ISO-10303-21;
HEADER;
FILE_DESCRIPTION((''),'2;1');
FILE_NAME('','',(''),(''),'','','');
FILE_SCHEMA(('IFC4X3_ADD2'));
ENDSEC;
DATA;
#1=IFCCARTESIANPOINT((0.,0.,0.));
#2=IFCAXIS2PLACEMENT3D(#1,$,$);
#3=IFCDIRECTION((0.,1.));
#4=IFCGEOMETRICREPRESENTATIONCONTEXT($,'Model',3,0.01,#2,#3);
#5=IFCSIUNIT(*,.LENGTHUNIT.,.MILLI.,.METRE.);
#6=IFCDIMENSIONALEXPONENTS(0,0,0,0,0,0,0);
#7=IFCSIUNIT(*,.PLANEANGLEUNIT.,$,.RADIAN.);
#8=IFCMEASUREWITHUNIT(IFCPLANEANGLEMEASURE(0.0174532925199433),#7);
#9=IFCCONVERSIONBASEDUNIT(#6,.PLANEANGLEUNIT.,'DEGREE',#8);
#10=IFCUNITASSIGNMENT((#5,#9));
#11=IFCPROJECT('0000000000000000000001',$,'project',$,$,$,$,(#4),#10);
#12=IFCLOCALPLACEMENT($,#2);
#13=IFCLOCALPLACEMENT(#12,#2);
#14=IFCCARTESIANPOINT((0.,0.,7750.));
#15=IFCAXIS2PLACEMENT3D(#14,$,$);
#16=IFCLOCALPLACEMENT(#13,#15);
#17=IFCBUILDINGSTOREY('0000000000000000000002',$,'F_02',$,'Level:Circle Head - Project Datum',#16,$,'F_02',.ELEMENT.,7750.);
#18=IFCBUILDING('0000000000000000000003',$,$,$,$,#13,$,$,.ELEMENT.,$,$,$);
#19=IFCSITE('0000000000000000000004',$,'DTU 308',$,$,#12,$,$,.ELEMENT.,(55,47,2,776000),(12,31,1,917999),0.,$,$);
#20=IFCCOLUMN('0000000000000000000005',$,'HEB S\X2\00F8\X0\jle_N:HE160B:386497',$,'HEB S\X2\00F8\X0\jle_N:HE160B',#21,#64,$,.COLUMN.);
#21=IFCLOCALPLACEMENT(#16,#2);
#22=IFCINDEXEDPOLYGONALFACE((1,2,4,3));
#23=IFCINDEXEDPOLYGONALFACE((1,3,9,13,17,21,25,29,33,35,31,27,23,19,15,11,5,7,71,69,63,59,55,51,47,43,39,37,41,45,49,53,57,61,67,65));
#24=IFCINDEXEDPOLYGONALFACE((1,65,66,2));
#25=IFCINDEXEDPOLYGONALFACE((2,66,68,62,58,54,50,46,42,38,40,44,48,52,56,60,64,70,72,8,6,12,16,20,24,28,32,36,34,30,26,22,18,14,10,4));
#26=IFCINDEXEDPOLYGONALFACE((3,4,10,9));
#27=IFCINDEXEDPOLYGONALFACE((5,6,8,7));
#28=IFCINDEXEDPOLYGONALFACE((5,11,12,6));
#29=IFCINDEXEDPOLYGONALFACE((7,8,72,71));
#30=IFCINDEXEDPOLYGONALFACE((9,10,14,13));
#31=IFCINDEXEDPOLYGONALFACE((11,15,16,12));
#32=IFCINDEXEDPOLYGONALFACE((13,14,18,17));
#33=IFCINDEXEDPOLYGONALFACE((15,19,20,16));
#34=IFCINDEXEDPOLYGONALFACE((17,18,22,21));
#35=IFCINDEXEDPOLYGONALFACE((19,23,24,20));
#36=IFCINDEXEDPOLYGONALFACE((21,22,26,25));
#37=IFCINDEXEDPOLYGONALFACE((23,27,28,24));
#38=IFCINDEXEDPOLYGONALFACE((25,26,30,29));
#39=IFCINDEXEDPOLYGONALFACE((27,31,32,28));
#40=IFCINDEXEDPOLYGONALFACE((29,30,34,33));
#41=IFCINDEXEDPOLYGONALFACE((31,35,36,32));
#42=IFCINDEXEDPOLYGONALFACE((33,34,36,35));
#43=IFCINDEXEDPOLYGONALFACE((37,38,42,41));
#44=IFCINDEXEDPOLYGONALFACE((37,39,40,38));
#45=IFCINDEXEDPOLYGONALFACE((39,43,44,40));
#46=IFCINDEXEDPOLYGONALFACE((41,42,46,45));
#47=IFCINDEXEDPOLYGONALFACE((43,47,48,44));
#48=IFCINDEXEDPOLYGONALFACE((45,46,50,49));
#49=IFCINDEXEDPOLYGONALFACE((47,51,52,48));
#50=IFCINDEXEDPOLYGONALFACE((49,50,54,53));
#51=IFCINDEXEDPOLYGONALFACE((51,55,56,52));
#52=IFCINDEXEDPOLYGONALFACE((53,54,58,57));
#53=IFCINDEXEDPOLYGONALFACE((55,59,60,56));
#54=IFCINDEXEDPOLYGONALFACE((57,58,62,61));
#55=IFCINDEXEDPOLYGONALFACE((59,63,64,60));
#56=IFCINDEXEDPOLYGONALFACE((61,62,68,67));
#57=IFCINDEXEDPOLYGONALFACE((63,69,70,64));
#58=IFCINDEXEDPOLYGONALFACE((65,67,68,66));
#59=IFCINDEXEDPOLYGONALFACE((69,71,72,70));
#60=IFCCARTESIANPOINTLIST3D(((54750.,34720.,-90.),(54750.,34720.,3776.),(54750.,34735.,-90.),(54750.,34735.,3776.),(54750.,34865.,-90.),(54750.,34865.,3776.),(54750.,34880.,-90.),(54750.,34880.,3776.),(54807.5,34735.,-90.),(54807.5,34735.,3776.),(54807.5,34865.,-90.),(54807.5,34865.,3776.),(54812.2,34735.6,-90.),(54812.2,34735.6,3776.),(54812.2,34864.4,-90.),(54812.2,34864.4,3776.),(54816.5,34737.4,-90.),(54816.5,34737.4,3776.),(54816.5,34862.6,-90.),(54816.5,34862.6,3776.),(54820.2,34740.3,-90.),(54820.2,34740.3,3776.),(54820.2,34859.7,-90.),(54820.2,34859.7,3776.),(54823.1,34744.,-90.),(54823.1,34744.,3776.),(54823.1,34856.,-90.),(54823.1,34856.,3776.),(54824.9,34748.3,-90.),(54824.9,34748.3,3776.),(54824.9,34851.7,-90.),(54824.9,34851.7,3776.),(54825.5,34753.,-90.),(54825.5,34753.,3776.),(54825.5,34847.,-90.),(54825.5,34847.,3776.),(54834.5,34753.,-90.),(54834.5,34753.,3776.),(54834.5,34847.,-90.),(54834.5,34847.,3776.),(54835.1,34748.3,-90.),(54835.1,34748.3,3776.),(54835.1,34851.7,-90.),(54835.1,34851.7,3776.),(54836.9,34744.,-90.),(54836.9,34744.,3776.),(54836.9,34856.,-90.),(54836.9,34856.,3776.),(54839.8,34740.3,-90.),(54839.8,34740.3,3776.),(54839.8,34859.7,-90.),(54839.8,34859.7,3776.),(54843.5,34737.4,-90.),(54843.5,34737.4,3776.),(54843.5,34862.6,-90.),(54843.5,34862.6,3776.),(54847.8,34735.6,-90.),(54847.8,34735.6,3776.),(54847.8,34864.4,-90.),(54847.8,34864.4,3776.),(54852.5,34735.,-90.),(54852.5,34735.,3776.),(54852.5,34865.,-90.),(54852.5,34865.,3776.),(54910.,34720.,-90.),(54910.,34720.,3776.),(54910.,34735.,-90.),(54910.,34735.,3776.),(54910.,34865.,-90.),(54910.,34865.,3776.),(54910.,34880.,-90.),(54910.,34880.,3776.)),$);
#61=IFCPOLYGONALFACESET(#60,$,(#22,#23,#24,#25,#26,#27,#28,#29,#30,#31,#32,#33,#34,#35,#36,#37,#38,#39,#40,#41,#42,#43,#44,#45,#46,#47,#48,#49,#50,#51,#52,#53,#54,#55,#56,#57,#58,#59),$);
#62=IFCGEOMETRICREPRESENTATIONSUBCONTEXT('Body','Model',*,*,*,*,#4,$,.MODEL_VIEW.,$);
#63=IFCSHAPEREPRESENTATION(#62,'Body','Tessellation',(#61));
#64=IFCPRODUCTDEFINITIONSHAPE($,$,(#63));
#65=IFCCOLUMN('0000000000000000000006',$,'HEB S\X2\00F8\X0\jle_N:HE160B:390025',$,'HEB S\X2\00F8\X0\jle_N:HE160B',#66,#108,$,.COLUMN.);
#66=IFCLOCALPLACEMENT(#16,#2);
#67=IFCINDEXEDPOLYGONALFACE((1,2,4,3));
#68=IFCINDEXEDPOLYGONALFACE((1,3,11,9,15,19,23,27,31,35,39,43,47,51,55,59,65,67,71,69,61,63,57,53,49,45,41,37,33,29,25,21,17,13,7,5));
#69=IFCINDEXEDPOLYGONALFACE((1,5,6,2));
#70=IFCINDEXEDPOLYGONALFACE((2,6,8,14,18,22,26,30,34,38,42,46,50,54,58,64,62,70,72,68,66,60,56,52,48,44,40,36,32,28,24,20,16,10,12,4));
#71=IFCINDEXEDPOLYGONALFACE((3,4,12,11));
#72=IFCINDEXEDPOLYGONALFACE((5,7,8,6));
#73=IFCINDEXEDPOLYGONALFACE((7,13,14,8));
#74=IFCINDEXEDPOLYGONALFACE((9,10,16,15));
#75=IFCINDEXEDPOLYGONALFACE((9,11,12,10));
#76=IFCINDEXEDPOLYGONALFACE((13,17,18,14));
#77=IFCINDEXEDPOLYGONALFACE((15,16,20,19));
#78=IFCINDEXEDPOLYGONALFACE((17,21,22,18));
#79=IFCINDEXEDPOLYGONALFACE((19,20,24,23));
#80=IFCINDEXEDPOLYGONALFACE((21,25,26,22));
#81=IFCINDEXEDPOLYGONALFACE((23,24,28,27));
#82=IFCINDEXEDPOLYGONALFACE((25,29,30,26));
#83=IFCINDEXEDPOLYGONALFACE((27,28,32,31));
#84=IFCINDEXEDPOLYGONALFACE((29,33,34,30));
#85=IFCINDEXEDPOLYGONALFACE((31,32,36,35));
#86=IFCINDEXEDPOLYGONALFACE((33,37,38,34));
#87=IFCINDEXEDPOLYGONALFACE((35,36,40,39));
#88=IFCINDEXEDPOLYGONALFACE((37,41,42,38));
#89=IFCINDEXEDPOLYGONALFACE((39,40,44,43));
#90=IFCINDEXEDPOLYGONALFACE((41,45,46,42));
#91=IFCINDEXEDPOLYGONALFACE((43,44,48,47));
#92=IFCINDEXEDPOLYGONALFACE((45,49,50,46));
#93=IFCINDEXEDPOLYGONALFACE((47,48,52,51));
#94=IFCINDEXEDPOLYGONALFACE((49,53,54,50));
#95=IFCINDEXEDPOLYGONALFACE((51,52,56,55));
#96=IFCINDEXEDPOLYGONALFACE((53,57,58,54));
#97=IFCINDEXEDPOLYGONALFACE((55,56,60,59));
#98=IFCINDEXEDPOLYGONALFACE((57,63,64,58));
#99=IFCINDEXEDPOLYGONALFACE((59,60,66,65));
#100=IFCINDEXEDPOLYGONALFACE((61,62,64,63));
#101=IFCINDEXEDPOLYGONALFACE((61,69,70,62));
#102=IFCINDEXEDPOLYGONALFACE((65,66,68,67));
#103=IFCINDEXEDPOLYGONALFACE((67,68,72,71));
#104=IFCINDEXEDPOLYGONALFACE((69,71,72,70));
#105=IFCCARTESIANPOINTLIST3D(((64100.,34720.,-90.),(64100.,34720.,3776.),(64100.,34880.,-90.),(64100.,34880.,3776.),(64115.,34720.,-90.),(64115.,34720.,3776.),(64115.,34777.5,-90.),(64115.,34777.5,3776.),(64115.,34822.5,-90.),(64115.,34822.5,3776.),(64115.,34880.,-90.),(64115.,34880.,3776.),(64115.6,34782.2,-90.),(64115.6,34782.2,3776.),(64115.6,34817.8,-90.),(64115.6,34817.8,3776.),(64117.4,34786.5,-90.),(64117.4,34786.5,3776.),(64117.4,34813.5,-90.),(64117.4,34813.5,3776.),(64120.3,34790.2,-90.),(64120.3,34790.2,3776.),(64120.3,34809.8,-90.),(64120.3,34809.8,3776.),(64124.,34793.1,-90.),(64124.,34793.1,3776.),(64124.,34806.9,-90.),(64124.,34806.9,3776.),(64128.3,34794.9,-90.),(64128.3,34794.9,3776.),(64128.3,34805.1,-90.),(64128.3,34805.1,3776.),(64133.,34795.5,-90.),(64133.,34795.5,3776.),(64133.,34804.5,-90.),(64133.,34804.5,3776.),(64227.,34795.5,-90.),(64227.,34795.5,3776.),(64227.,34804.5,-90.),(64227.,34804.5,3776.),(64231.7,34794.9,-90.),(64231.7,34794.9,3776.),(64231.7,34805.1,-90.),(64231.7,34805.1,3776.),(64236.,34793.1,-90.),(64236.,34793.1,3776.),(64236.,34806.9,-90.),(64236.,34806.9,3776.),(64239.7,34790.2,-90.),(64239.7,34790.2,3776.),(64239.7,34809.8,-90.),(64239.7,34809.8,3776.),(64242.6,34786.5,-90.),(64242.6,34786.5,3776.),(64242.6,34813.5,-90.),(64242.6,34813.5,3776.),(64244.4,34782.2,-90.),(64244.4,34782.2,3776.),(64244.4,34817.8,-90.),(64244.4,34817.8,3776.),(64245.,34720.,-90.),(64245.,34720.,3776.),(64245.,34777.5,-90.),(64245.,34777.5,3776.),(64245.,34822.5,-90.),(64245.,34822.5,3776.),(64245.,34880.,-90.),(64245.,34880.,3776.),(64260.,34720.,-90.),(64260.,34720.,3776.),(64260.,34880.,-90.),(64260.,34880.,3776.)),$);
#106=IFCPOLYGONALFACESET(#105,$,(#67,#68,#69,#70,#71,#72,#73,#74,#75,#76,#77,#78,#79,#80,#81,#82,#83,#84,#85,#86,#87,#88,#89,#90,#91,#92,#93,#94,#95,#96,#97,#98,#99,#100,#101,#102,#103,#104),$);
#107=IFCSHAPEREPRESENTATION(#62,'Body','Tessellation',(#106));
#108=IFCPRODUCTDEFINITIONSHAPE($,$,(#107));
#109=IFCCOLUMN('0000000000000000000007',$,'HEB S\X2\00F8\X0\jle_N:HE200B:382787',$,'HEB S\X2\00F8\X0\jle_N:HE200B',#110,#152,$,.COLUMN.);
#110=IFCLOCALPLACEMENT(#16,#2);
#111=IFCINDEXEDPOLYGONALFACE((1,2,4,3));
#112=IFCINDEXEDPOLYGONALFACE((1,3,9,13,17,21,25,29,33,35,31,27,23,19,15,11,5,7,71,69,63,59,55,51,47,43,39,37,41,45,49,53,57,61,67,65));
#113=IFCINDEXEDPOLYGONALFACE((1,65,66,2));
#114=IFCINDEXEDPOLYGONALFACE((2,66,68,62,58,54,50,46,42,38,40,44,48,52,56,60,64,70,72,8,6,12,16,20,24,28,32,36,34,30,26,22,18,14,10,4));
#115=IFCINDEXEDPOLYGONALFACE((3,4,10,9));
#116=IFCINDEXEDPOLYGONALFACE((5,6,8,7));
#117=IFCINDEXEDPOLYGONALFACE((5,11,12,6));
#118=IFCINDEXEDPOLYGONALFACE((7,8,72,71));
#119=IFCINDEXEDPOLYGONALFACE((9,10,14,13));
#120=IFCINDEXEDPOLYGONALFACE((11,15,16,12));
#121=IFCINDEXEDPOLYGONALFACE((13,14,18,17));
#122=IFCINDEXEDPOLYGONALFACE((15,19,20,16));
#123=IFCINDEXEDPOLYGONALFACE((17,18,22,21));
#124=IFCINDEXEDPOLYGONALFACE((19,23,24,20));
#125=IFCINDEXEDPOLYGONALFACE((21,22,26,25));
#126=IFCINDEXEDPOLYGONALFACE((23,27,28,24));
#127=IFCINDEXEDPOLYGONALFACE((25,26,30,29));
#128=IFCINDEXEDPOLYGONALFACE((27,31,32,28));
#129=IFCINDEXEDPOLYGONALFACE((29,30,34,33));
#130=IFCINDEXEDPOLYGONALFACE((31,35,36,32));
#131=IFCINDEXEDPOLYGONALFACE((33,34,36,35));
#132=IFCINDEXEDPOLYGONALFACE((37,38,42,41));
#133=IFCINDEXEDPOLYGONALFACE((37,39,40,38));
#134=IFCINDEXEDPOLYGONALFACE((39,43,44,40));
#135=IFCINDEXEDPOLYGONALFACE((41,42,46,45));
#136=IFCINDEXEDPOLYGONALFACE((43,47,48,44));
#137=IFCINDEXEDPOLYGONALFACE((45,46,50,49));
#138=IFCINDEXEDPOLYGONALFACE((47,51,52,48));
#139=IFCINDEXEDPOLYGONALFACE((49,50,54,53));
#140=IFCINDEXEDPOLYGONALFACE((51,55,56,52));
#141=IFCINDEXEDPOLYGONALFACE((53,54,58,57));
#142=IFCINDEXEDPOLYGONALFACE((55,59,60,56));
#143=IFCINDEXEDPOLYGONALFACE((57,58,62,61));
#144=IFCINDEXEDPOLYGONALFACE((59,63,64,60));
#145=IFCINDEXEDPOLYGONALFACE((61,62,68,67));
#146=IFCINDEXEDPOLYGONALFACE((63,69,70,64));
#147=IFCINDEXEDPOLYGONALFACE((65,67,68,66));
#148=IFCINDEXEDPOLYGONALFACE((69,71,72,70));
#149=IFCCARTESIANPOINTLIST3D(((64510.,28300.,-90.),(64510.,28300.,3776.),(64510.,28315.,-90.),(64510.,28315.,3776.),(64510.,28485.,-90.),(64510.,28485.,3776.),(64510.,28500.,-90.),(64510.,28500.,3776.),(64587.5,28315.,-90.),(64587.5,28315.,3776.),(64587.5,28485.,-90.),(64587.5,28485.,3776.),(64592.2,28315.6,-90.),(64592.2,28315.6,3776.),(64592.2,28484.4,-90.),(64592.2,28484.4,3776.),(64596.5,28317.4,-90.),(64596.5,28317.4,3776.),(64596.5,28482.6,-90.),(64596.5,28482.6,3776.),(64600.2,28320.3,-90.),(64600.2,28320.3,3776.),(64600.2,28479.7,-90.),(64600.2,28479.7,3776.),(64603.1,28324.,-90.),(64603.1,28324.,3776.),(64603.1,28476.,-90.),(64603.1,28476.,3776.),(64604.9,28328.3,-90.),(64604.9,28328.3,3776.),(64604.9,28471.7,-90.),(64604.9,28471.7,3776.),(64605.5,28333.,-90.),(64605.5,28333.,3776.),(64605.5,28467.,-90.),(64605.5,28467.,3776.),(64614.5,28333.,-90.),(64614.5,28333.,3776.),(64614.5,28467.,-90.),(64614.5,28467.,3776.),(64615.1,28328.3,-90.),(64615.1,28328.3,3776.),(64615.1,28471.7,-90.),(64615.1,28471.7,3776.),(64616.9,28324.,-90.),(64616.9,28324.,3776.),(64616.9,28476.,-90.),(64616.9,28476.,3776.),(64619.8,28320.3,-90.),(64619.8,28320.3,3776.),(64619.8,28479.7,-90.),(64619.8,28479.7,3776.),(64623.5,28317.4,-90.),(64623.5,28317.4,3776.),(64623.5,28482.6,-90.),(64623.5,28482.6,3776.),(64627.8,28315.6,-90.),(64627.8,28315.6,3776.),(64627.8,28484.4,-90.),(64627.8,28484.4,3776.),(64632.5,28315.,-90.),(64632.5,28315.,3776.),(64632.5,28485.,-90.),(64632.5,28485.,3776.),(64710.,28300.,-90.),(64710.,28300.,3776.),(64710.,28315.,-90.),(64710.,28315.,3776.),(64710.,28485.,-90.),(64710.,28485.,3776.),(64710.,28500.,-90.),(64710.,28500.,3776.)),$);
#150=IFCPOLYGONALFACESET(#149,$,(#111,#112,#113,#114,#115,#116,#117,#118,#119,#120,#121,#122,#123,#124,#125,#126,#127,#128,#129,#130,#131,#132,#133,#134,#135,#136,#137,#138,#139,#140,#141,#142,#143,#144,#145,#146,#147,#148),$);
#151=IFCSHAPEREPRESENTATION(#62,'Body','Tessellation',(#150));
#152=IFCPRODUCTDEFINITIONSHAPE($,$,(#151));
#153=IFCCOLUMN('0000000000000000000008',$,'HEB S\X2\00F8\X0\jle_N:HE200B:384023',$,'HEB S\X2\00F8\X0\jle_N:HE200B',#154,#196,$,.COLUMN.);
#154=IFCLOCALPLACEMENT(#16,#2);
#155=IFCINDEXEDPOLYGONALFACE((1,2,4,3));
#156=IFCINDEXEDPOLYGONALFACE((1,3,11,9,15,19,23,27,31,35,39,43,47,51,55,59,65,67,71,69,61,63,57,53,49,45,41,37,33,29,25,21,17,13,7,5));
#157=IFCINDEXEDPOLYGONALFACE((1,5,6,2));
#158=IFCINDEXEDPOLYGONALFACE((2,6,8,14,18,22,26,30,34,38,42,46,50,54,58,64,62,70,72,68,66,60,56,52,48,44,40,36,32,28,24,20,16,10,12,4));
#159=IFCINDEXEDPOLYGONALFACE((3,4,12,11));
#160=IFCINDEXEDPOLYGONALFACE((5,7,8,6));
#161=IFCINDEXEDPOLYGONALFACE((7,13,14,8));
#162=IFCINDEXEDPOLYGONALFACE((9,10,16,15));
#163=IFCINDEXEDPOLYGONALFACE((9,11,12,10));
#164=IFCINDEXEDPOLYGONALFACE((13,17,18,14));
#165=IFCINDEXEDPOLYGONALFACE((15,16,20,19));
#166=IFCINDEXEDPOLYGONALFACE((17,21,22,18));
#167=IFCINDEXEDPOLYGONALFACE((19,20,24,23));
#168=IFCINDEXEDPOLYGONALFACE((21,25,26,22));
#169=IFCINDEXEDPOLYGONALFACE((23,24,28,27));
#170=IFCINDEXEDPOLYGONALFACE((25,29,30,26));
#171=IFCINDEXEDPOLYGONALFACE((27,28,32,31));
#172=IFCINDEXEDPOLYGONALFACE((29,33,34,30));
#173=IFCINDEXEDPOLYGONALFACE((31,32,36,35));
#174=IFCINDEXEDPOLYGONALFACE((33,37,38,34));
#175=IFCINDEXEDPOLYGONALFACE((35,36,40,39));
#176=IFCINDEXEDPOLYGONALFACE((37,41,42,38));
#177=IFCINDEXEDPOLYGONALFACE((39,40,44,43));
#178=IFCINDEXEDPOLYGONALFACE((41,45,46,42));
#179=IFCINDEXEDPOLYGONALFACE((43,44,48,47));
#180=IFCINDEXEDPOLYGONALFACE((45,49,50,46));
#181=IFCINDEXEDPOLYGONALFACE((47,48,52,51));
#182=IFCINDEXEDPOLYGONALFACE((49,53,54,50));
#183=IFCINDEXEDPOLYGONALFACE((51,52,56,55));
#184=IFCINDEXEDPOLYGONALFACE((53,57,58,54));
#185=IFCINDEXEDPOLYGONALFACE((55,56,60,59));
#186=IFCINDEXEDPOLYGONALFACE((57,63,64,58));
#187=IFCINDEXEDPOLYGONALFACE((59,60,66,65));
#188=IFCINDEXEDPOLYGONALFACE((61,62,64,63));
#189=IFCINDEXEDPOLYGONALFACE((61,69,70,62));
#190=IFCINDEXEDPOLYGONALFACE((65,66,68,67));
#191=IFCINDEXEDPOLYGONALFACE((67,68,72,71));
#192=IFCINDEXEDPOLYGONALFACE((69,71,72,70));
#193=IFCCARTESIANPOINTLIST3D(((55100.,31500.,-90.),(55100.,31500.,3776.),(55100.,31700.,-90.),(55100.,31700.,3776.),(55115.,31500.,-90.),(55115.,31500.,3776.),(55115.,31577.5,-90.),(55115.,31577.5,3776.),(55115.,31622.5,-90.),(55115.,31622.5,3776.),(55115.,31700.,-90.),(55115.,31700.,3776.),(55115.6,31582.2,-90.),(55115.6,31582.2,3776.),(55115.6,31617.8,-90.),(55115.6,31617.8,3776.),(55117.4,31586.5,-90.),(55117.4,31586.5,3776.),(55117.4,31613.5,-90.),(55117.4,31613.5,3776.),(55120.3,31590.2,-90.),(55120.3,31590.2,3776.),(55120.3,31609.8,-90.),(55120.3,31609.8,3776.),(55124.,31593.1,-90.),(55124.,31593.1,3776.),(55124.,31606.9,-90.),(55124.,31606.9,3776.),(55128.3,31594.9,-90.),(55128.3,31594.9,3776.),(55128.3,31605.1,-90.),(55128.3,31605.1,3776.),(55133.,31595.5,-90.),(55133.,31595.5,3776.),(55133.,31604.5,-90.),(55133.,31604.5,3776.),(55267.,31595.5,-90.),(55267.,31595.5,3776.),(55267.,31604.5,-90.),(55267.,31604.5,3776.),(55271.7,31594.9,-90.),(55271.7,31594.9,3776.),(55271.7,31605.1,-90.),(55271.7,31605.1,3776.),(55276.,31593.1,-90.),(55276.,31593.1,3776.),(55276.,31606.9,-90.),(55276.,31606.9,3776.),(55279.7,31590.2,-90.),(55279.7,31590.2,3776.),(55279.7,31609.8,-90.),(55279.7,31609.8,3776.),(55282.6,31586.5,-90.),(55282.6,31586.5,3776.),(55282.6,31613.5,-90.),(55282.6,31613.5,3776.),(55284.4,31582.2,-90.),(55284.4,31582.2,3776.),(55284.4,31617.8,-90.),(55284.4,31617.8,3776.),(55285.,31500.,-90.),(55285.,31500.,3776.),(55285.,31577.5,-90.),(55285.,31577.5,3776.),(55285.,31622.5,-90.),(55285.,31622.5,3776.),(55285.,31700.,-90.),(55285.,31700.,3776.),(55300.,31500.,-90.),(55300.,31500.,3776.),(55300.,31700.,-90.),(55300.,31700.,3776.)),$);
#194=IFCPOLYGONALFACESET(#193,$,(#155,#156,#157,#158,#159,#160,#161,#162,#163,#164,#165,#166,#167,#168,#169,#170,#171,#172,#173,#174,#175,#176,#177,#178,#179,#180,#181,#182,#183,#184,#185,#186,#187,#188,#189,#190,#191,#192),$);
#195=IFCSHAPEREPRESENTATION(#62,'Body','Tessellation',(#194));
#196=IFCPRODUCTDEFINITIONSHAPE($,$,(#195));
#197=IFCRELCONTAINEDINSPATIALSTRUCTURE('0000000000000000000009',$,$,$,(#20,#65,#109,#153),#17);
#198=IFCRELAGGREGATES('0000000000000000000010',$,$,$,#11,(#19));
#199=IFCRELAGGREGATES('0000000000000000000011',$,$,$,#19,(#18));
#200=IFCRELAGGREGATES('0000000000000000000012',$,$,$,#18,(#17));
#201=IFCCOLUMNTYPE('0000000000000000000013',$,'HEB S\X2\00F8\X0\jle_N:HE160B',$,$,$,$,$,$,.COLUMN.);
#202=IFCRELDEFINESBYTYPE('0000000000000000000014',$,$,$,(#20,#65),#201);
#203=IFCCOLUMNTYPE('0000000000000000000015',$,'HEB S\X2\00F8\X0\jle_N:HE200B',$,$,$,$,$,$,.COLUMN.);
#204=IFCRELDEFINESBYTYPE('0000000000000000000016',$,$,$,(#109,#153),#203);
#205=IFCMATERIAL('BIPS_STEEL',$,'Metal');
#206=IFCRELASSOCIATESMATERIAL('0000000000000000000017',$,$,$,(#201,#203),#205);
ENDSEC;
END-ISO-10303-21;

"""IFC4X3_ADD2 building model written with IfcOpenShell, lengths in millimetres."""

from ifc_helpers import new_model, entity, si_unit, converted_unit, direction, frame, frame_2d, origin, place, context, subcontext, project, spatial, i_section, extrude, source, transform, mapped, material, material_profile, profile_set, type_object, element, save


model = new_model("IFC4X3_ADD2")

# Units and contexts
model_context = context("Model", 3, precision=0.01, world=origin(), true_north=direction((0.0, 1.0)))
body_context = subcontext(model_context, "Body", "Model", "MODEL_VIEW")
ifc_project = project(units=[si_unit("LENGTHUNIT", "METRE", prefix="MILLI"), converted_unit("PLANEANGLEUNIT", "DEGREE", entity("IfcPlaneAngleMeasure", 0.0174532925199433), si_unit("PLANEANGLEUNIT", "RADIAN"), dimensions=[0, 0, 0, 0, 0, 0, 0])], contexts=[model_context])

# Site, building, storey
site_placement = place(None, origin())
site = spatial("IfcSite", under=ifc_project, at=site_placement, Name="DTU 308", CompositionType="ELEMENT", RefLatitude=(55, 47, 2, 776000), RefLongitude=(12, 31, 1, 917999), RefElevation=0.0)
building_placement = place(site_placement, origin())
building = spatial("IfcBuilding", under=site, at=building_placement, CompositionType="ELEMENT")
storey_placement = place(building_placement, frame((0.0, 0.0, 7750.0)))
storey = spatial("IfcBuildingStorey", under=building, at=storey_placement, Name="F_02", ObjectType="Level:Circle Head - Project Datum", LongName="F_02", CompositionType="ELEMENT", Elevation=7750.0)

# Columns
ifc_material = material(Name="BIPS_STEEL", Category="Metal")
ifc_material_profile_1 = material_profile(ifc_material, i_section(OverallWidth=160.0, OverallDepth=160.0, WebThickness=9.0, FlangeThickness=15.0, FilletRadius=18.0, at=frame_2d((0.0, 0.0), x_axis=(1.0, 0.0))), Name="HE160B")
ifc_profile_set_1 = profile_set([ifc_material_profile_1], Name="HE160B")
column_type_1 = type_object("IfcColumnType", Name="HEB Søjle_N:HE160B", PredefinedType="COLUMN", material=ifc_profile_set_1)
shared_shape_1 = source(origin(), body_context, "Body", "SweptSolid", [
    extrude(i_section(OverallWidth=160.0, OverallDepth=160.0, WebThickness=9.0, FlangeThickness=15.0, FilletRadius=18.0, at=frame_2d((0.0, 0.0), x_axis=(1.0, 0.0))), frame((0.0, 0.0, 7660.0), z_axis=(0.0, 0.0, 1.0), x_axis=(-1.0, 0.0, 0.0)), (0.0, 0.0, 1.0), 3866.0),
])
for number, where, name in (
    (1, (54830.0, 34800.0, -7750.0), "HEB Søjle_N:HE160B:386497"),
):
    element("IfcColumn", number, at=place(storey_placement, frame(where)), inside=storey, type_object=column_type_1, Name=name, ObjectType="HEB Søjle_N:HE160B", PredefinedType="COLUMN", context=body_context, shape_type="MappedRepresentation", body=[
        mapped(shared_shape_1, transform((0.0, 0.0, 0.0), scale=1.0)),
    ])
column_1_placement = place(storey_placement, frame((64180.0, 34800.0, -7750.0), z_axis=(0.0, 0.0, 1.0), x_axis=(0.0, 1.0, 0.0)))
element("IfcColumn", 2, at=column_1_placement, inside=storey, type_object=column_type_1, Name="HEB Søjle_N:HE160B:390025", ObjectType="HEB Søjle_N:HE160B", PredefinedType="COLUMN", context=body_context, shape_type="MappedRepresentation", body=[
    mapped(shared_shape_1, transform((0.0, 0.0, 0.0), scale=1.0)),
])
ifc_material_profile_2 = material_profile(ifc_material, i_section(OverallWidth=200.0, OverallDepth=200.0, WebThickness=9.0, FlangeThickness=15.0, FilletRadius=18.0, at=frame_2d((0.0, 0.0), x_axis=(1.0, 0.0))), Name="HE200B")
ifc_profile_set_2 = profile_set([ifc_material_profile_2], Name="HE200B")
column_type_2 = type_object("IfcColumnType", Name="HEB Søjle_N:HE200B", PredefinedType="COLUMN", material=ifc_profile_set_2)
shared_shape_2 = source(origin(), body_context, "Body", "SweptSolid", [
    extrude(i_section(OverallWidth=200.0, OverallDepth=200.0, WebThickness=9.0, FlangeThickness=15.0, FilletRadius=18.0, at=frame_2d((0.0, 0.0), x_axis=(1.0, 0.0))), frame((0.0, 0.0, 7660.0), z_axis=(0.0, 0.0, 1.0), x_axis=(-1.0, 0.0, 0.0)), (0.0, 0.0, 1.0), 3866.0),
])
column_2_placement = place(storey_placement, frame((64610.0, 28400.0, -7750.0)))
element("IfcColumn", 3, at=column_2_placement, inside=storey, type_object=column_type_2, Name="HEB Søjle_N:HE200B:382787", ObjectType="HEB Søjle_N:HE200B", PredefinedType="COLUMN", context=body_context, shape_type="MappedRepresentation", body=[
    mapped(shared_shape_2, transform((0.0, 0.0, 0.0), scale=1.0)),
])
column_3_placement = place(storey_placement, frame((55200.0, 31600.0, -7750.0), z_axis=(0.0, 0.0, 1.0), x_axis=(0.0, 1.0, 0.0)))
element("IfcColumn", 4, at=column_3_placement, inside=storey, type_object=column_type_2, Name="HEB Søjle_N:HE200B:384023", ObjectType="HEB Søjle_N:HE200B", PredefinedType="COLUMN", context=body_context, shape_type="MappedRepresentation", body=[
    mapped(shared_shape_2, transform((0.0, 0.0, 0.0), scale=1.0)),
])

save(model, "model.ifc")
